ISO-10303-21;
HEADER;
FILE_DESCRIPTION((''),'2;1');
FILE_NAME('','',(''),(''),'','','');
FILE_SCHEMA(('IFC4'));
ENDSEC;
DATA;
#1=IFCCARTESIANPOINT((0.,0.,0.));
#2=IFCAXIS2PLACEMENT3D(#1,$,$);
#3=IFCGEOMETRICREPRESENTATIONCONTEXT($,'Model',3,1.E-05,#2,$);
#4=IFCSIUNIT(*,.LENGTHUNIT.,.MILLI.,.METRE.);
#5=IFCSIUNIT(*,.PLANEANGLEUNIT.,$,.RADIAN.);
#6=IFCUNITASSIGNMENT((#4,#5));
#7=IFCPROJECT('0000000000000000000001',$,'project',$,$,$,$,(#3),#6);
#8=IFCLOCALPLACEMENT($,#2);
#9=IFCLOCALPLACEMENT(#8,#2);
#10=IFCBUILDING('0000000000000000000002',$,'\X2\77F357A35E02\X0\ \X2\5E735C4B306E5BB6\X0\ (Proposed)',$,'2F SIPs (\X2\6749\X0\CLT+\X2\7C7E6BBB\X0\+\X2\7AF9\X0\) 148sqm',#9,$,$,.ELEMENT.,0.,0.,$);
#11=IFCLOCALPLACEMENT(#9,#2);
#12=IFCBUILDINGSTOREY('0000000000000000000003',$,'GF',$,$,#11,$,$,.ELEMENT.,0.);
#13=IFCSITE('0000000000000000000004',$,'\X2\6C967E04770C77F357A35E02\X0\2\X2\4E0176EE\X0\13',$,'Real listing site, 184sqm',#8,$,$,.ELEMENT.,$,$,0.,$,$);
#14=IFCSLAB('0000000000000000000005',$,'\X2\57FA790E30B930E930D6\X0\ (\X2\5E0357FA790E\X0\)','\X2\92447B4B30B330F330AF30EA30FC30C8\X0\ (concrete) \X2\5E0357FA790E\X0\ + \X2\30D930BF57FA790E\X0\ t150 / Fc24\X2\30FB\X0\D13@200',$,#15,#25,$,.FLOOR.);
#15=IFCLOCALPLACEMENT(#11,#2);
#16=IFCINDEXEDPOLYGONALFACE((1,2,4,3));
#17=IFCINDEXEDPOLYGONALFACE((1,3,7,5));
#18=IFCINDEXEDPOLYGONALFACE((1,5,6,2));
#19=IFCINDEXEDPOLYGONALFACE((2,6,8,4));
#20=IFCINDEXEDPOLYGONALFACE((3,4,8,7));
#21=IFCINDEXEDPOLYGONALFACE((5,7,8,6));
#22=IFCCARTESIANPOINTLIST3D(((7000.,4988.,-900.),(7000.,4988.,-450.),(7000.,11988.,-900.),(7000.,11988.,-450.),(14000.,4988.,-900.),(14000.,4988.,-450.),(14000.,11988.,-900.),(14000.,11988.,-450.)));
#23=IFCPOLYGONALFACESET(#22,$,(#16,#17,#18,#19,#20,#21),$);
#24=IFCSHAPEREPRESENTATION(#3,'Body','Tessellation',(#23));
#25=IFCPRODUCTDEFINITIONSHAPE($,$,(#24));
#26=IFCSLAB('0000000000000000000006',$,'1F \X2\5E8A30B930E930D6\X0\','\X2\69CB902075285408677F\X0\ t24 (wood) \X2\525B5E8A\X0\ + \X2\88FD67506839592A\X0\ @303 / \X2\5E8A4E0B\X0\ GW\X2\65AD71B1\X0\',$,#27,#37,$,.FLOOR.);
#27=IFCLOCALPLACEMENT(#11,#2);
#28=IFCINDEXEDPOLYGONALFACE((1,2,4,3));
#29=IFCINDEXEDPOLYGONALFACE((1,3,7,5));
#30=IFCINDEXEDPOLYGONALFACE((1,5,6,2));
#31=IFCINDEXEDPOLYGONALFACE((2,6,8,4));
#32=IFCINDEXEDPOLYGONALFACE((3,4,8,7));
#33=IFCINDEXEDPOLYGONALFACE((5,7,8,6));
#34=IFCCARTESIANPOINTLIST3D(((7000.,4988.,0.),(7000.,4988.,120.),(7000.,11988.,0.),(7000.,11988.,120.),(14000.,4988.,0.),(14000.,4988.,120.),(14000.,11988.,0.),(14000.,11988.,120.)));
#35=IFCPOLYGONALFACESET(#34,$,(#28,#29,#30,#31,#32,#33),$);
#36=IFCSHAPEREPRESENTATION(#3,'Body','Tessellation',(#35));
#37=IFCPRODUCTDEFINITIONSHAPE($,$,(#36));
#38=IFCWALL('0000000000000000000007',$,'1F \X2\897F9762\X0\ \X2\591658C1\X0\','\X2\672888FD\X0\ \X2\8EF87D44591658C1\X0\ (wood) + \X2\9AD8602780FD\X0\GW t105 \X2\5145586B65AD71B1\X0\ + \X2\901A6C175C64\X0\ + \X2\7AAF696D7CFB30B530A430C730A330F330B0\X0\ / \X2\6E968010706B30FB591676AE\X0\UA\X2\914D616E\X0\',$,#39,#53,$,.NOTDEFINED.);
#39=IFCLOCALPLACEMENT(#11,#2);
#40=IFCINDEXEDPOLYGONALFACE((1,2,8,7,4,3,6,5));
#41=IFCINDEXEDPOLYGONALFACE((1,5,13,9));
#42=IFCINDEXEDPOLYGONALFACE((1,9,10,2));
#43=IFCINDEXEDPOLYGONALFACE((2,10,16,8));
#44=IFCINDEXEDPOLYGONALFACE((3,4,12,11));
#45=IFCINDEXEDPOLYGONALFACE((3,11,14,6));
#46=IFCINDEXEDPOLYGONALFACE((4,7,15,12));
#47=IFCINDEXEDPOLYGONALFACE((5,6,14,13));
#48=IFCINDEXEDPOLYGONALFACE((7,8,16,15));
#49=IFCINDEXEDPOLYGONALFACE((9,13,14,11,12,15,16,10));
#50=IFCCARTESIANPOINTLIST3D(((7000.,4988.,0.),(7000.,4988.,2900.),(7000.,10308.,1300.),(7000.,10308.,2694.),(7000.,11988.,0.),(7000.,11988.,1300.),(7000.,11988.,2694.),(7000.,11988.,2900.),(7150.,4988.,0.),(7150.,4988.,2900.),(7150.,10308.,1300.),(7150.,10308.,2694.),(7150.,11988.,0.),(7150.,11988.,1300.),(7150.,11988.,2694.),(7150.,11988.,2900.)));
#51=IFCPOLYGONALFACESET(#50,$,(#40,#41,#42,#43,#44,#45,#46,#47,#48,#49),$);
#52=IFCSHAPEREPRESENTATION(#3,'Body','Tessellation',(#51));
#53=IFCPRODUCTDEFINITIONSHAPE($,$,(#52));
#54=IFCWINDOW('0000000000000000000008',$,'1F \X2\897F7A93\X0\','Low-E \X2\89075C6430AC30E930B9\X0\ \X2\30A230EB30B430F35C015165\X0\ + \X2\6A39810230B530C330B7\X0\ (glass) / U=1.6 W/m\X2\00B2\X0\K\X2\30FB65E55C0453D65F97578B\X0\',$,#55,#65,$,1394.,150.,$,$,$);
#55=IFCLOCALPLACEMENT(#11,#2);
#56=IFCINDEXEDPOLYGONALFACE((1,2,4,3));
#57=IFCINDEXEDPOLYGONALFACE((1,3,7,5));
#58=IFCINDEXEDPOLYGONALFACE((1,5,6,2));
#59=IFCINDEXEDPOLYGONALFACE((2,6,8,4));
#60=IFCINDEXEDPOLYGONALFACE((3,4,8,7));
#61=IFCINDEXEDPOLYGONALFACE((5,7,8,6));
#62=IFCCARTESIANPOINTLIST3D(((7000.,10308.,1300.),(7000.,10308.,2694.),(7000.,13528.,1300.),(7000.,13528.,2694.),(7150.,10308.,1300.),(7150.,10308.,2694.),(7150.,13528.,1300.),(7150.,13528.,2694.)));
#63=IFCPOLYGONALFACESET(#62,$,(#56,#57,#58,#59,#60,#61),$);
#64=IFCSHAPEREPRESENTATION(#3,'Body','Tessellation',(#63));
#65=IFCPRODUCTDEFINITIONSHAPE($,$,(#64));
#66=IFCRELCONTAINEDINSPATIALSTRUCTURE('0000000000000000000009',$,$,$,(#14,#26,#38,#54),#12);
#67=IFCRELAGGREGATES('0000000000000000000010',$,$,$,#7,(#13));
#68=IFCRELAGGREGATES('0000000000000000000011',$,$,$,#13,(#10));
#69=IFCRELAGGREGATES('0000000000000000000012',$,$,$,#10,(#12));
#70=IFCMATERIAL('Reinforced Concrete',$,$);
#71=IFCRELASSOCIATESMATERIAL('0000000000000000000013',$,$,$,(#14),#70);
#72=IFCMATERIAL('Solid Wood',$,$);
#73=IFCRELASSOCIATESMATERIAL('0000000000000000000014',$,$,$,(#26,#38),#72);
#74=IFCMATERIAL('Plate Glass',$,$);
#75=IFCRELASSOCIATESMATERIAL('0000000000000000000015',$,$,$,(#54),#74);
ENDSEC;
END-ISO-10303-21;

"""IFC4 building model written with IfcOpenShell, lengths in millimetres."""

from ifc_helpers import new_model, si_unit, frame, frame_2d, origin, place, context, project, spatial, rectangle, extrude, material, element, fill, save


model = new_model("IFC4")

# Units and contexts
model_context = context("Model", 3, precision=1e-05, world=origin())
ifc_project = project(units=[si_unit("LENGTHUNIT", "METRE", prefix="MILLI"), si_unit("PLANEANGLEUNIT", "RADIAN")], contexts=[model_context])

# Site, building, storey
site_placement = place(None, origin())
site = spatial("IfcSite", under=ifc_project, at=site_placement, Name="沖縄県石垣市2丁目13", ObjectType="Real listing site, 184sqm", CompositionType="ELEMENT", RefElevation=0.0)
building_placement = place(site_placement, origin())
building = spatial("IfcBuilding", under=site, at=building_placement, Name="石垣市 平屋の家 (Proposed)", ObjectType="2F SIPs (杉CLT+籾殻+竹) 148sqm", CompositionType="ELEMENT", ElevationOfRefHeight=0.0, ElevationOfTerrain=0.0)
storey_placement = place(building_placement, origin())
storey = spatial("IfcBuildingStorey", under=building, at=storey_placement, Name="GF", CompositionType="ELEMENT", Elevation=0.0)

# Slabs
ifc_material_1 = material(Name="Reinforced Concrete")
slab_1_placement = place(storey_placement, frame((3500.0, 2494.0, -450.0)))
element("IfcSlab", 1, at=slab_1_placement, inside=storey, material=ifc_material_1, Name="基礎スラブ (布基礎)", Description="鉄筋コンクリート (concrete) 布基礎 + ベタ基礎 t150 / Fc24・D13@200", PredefinedType="FLOOR", context=model_context, shape_type="SweptSolid", body=[
    extrude(rectangle(XDim=7000.0, YDim=7000.0, at=frame_2d((3500.0, 3500.0))), frame((3500.0, 2494.0, -450.0)), (0.0, 0.0, 1.0), 450.0),
])
ifc_material_2 = material(Name="Solid Wood")
slab_2_placement = place(storey_placement, frame((3500.0, 2494.0, 0.0)))
element("IfcSlab", 2, at=slab_2_placement, inside=storey, material=ifc_material_2, Name="1F 床スラブ", Description="構造用合板 t24 (wood) 剛床 + 製材根太 @303 / 床下 GW断熱", PredefinedType="FLOOR", context=model_context, shape_type="SweptSolid", body=[
    extrude(rectangle(XDim=7000.0, YDim=7000.0, at=frame_2d((3500.0, 3500.0))), frame((3500.0, 2494.0, 0.0)), (0.0, 0.0, 1.0), 120.0),
])

# Shared definitions
ifc_material_3 = material(Name="Plate Glass")

# Wall, opening, window
wall_1_placement = place(storey_placement, frame((3500.0, 2494.0, 0.0)))
wall_1 = element("IfcWall", 3, at=wall_1_placement, inside=storey, material=ifc_material_2, Name="1F 西面 外壁", Description="木製 軸組外壁 (wood) + 高性能GW t105 充填断熱 + 通気層 + 窯業系サイディング / 準耐火・外皮UA配慮", PredefinedType="NOTDEFINED", context=model_context, shape_type="SweptSolid", body=[
    extrude(rectangle(XDim=150.0, YDim=7000.0, at=frame_2d((75.0, 3500.0))), frame((3500.0, 2494.0, 0.0)), (0.0, 0.0, 1.0), 2900.0),
])
opening_1_placement = place(storey_placement, frame((3500.0, 5154.0, 650.0)))
opening_1 = element("IfcOpeningElement", 4, at=opening_1_placement, cuts=wall_1, PredefinedType="NOTDEFINED", context=model_context, shape_type="SweptSolid", body=[
    extrude(rectangle(XDim=150.0, YDim=3220.0, at=frame_2d((75.0, 1610.0))), frame((3500.0, 5154.0, 650.0)), (0.0, 0.0, 1.0), 1394.0),
])
window_1_placement = place(storey_placement, frame((3500.0, 5154.0, 650.0)))
window_1 = element("IfcWindow", 5, at=window_1_placement, inside=storey, material=ifc_material_3, Name="1F 西窓", Description="Low-E 複層ガラス アルゴン封入 + 樹脂サッシ (glass) / U=1.6 W/m²K・日射取得型", OverallHeight=1394.0, OverallWidth=150.0, context=model_context, shape_type="SweptSolid", body=[
    extrude(rectangle(XDim=150.0, YDim=3220.0, at=frame_2d((75.0, 1610.0))), frame((3500.0, 5154.0, 650.0)), (0.0, 0.0, 1.0), 1394.0),
])
fill(opening_1, window_1)

save(model, "model.ifc")
